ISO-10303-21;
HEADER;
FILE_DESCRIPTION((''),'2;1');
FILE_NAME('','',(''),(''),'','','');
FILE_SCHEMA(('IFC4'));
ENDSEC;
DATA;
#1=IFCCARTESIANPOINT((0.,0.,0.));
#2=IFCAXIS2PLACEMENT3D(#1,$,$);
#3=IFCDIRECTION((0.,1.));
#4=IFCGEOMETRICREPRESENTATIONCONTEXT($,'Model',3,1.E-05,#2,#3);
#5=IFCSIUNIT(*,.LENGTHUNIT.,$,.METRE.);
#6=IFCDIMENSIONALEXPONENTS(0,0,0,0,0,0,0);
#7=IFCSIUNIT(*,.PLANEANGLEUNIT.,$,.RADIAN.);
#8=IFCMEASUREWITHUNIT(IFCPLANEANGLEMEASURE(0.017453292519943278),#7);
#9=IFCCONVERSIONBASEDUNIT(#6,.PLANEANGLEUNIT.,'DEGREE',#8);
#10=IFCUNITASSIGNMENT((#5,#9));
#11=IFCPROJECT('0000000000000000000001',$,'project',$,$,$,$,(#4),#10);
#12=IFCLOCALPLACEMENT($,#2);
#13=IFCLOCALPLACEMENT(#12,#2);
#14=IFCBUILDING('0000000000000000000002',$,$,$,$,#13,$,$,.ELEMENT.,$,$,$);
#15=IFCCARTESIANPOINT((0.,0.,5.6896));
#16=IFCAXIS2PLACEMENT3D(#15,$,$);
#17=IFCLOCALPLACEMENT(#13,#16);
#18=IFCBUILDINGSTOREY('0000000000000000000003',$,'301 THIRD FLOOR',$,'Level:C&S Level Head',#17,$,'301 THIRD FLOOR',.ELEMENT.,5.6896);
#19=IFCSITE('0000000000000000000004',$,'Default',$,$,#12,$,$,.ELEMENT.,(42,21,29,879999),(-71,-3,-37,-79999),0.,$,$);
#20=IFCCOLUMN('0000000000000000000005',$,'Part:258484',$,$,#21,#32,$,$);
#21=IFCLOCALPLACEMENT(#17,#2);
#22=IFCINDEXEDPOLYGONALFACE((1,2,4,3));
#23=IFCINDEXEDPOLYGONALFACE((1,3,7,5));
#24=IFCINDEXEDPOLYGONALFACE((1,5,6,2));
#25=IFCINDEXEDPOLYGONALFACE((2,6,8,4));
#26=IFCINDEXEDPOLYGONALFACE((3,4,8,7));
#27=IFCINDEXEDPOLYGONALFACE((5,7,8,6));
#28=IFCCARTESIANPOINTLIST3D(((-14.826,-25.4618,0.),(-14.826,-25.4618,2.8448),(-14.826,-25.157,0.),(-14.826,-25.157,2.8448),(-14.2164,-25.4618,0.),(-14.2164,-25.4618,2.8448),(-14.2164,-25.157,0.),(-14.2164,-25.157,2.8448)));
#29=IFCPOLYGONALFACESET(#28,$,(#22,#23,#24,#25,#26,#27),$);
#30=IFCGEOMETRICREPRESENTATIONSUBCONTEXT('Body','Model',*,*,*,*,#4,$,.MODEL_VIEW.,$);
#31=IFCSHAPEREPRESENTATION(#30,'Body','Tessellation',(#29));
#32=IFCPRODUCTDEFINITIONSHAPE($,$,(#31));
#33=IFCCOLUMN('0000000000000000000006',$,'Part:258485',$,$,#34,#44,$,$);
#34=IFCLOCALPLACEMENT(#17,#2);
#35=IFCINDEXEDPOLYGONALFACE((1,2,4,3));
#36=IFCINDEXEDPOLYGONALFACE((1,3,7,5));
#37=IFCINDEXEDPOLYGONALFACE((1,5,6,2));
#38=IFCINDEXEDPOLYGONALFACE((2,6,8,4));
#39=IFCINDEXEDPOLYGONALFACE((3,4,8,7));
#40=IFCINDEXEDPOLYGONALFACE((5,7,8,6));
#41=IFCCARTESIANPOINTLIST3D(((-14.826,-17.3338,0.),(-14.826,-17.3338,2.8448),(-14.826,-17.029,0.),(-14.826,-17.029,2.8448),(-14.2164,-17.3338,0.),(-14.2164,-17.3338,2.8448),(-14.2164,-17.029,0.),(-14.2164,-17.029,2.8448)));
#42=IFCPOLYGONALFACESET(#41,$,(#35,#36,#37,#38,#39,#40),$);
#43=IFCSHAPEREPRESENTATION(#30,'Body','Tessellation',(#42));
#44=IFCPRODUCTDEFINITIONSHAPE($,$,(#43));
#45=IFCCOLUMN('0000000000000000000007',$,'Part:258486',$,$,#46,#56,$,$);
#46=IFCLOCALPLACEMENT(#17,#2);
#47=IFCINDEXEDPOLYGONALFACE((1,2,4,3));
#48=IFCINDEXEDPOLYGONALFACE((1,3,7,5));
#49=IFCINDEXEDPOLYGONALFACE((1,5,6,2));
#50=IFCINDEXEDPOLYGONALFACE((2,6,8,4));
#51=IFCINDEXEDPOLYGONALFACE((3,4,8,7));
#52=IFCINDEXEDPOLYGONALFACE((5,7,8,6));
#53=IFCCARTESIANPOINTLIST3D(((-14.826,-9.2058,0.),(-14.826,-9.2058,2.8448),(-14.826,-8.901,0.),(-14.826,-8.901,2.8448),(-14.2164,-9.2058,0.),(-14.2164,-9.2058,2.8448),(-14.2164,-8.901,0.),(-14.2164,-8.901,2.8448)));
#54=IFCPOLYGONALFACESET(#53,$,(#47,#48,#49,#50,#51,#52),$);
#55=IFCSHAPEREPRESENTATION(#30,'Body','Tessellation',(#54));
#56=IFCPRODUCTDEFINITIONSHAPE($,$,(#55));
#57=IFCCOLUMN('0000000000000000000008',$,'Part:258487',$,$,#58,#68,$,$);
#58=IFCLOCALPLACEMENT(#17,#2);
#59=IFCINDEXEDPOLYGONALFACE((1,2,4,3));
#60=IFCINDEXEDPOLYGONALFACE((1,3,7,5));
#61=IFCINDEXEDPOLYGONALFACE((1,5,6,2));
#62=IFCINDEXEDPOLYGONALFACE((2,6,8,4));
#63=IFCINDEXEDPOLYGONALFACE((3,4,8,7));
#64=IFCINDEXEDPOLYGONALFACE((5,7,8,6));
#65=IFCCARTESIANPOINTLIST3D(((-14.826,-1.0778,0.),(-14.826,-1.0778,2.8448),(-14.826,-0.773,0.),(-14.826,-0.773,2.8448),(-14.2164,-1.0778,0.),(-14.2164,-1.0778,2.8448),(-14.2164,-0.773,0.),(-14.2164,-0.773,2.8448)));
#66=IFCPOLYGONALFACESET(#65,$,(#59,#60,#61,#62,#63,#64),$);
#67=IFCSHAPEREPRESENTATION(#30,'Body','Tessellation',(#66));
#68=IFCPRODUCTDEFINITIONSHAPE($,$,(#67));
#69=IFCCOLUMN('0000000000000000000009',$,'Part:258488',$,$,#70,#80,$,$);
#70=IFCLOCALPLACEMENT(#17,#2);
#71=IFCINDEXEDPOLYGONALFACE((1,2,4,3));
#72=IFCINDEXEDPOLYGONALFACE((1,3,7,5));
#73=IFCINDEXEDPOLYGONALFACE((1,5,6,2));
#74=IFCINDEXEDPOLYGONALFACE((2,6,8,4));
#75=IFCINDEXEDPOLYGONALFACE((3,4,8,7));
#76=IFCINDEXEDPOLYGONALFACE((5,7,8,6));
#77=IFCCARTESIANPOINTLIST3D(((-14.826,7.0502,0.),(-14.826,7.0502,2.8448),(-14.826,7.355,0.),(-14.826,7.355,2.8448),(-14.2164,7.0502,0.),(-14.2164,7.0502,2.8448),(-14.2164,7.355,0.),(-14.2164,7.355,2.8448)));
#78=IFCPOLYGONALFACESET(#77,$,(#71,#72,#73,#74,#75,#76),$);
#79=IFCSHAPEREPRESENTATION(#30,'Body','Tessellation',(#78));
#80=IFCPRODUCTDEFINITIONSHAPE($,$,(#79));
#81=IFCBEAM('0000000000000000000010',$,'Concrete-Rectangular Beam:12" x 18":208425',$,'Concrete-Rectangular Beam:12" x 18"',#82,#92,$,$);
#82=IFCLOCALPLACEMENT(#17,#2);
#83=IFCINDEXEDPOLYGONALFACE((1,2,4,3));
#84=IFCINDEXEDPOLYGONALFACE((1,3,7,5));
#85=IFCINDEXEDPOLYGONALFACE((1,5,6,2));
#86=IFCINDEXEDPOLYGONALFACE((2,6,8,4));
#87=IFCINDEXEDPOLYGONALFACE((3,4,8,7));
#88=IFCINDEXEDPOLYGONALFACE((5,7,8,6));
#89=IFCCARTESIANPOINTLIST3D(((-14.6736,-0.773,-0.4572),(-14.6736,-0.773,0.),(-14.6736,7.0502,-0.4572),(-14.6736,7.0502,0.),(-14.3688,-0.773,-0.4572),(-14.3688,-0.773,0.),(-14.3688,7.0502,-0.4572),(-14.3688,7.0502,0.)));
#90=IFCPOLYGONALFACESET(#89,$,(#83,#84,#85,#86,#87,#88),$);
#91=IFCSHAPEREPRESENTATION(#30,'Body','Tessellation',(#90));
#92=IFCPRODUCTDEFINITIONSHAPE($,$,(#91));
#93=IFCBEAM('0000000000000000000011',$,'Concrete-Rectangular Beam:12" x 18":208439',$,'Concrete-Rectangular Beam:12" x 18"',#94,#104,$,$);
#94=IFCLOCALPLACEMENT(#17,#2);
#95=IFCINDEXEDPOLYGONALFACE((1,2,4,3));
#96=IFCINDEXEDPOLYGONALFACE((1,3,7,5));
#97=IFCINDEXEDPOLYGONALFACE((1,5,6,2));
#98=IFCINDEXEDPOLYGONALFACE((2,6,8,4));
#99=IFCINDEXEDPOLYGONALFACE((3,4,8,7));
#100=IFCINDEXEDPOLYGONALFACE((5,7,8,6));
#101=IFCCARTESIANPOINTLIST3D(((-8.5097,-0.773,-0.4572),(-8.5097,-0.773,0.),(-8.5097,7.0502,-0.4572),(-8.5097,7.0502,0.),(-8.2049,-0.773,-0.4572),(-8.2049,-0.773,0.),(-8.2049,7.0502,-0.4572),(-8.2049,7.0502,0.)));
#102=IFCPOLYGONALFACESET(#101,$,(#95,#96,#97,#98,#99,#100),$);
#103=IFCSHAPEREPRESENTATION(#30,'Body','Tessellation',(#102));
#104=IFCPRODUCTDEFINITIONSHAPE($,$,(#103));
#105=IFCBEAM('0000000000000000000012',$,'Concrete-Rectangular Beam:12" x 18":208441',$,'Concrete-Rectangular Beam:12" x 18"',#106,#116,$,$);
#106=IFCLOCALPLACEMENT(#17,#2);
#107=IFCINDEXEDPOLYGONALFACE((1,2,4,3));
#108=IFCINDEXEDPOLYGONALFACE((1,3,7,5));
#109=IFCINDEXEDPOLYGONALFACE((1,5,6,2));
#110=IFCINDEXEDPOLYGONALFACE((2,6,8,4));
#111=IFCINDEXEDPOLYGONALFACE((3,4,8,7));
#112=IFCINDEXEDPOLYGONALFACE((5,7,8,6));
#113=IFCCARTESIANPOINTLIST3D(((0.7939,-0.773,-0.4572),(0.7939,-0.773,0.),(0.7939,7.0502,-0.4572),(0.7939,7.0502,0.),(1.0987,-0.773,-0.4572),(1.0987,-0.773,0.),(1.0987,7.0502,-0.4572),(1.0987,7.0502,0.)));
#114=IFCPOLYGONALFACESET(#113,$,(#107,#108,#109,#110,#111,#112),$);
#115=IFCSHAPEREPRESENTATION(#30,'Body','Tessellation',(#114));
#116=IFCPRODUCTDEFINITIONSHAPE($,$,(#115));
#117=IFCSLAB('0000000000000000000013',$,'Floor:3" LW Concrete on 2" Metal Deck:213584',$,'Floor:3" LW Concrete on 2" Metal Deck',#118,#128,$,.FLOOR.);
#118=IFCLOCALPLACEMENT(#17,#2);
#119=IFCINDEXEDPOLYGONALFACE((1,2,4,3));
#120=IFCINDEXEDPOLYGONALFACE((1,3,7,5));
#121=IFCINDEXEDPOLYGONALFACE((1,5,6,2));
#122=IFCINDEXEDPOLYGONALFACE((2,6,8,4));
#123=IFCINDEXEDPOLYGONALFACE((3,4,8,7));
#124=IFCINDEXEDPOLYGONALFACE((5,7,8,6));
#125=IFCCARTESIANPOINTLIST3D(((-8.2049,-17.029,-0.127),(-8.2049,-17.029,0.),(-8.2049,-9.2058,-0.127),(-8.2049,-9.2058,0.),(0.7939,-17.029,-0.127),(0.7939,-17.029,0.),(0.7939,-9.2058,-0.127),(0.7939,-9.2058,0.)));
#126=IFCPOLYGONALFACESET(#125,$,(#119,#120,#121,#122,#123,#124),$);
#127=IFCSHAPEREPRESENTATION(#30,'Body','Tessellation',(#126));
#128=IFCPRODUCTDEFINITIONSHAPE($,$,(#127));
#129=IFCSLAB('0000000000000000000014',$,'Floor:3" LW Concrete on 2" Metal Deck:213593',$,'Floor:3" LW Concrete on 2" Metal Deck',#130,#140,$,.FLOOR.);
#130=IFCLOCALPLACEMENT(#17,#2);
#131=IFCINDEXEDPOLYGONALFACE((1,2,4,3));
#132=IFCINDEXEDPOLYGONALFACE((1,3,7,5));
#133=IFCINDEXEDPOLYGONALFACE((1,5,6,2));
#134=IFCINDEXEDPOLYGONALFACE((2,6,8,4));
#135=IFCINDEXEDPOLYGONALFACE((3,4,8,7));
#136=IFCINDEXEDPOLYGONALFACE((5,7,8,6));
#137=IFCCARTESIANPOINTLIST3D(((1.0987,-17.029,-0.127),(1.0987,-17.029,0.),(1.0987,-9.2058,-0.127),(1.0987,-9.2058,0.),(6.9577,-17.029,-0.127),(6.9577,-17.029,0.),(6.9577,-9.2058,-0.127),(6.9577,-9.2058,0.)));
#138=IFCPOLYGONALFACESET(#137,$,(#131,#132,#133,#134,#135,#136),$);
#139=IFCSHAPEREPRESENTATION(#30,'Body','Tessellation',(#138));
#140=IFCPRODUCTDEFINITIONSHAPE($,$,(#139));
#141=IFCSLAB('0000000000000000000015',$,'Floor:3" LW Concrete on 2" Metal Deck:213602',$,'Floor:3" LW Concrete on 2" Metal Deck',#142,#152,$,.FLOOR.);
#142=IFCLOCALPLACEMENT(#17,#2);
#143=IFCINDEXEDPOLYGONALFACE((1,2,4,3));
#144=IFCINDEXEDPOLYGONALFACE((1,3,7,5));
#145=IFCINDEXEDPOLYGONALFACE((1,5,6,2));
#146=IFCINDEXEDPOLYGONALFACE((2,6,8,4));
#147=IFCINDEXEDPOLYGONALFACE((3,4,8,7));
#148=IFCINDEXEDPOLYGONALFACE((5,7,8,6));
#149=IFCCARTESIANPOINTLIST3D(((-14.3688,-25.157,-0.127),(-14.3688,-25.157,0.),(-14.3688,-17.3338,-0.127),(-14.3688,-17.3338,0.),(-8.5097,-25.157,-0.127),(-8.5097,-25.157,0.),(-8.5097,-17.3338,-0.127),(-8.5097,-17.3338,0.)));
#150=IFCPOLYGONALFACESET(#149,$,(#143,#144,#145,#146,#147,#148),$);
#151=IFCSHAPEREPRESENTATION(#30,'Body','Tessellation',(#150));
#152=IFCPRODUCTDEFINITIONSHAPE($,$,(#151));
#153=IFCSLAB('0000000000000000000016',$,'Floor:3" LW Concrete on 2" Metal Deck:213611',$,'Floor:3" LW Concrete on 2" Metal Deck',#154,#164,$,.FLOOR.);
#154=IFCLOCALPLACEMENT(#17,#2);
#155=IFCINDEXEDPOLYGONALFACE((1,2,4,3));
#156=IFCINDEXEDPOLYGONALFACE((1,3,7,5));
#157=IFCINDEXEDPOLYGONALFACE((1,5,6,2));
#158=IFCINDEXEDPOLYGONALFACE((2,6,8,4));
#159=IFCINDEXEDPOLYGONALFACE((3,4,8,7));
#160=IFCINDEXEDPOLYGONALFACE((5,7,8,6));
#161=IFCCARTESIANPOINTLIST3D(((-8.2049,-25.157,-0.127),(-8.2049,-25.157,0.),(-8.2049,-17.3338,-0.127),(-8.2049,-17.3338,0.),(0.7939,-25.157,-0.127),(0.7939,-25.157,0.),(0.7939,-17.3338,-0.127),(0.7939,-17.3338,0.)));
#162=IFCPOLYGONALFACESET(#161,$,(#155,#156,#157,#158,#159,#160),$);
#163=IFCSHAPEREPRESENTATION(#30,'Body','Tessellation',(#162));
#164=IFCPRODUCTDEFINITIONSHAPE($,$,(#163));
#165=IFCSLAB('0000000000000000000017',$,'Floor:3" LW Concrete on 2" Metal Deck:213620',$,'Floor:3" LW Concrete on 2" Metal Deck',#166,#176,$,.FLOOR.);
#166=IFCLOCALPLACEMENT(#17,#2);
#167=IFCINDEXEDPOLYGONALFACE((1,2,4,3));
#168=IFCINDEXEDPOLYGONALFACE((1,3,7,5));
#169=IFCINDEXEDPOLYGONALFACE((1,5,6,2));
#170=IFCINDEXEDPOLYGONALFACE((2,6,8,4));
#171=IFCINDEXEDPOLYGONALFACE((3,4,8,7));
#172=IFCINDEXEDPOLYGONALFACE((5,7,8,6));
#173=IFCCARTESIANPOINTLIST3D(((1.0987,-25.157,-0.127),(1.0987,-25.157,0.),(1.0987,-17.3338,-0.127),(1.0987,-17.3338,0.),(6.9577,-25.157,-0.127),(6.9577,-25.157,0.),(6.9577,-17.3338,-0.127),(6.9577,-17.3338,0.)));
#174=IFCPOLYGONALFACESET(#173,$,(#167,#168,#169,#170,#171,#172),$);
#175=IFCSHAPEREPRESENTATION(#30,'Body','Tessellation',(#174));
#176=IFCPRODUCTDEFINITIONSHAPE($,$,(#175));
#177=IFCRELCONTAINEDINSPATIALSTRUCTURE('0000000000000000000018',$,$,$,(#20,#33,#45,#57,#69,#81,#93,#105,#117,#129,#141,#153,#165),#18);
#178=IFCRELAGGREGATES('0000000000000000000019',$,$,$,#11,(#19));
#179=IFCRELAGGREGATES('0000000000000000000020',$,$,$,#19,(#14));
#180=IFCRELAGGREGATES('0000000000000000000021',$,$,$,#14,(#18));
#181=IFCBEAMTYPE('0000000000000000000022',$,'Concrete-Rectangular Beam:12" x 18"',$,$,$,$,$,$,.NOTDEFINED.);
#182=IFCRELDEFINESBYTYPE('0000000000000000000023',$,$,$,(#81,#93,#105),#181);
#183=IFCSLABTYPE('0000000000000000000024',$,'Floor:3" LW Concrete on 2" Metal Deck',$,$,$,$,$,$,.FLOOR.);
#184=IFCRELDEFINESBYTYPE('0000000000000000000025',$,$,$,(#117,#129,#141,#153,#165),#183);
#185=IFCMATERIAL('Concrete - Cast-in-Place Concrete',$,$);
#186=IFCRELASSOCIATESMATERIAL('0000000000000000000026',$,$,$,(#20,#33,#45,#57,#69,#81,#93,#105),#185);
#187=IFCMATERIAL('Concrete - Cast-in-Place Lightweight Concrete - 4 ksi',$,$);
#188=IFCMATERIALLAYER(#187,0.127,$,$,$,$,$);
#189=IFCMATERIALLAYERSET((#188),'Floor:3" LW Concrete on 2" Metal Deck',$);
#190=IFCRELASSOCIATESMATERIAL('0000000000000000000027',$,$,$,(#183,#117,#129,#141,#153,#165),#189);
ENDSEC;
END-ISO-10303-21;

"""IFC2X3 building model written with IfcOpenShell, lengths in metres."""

from ifc_helpers import new_model, entity, si_unit, converted_unit, direction, frame, frame_2d, origin, origin_2d_with_axis, place, context, subcontext, project, spatial, rectangle, extrude, material, layer, layer_set, layer_usage, type_object, element, save


model = new_model("IFC2X3")

# Units and contexts
model_context = context("Model", 3, precision=1e-05, world=origin(), true_north=direction((0.0, 1.0)))
body_context = subcontext(model_context, "Body", "Model", "MODEL_VIEW")
ifc_project = project(units=[si_unit("LENGTHUNIT", "METRE"), converted_unit("PLANEANGLEUNIT", "DEGREE", entity("IfcPlaneAngleMeasure", 0.017453292519943278), si_unit("PLANEANGLEUNIT", "RADIAN"), dimensions=[0, 0, 0, 0, 0, 0, 0])], contexts=[model_context])

# Site, building, storey
site_placement = place(None, origin())
site = spatial("IfcSite", under=ifc_project, at=site_placement, Name="Default", CompositionType="ELEMENT", RefLatitude=(42, 21, 29, 879999), RefLongitude=(-71, -3, -37, -79999), RefElevation=0.0)
building_placement = place(site_placement, origin())
building = spatial("IfcBuilding", under=site, at=building_placement, CompositionType="ELEMENT")
storey_placement = place(building_placement, frame((0.0, 0.0, 5.6896)))
storey = spatial("IfcBuildingStorey", under=building, at=storey_placement, Name="301 THIRD FLOOR", ObjectType="Level:C&S Level Head", LongName="301 THIRD FLOOR", CompositionType="ELEMENT", Elevation=5.6896)

# Columns
ifc_material_1 = material(Name="Concrete - Cast-in-Place Concrete")
column_1_placement = place(storey_placement, origin())
element("IfcColumn", 1, at=column_1_placement, inside=storey, material=ifc_material_1, Name="Part:258484", context=body_context, shape_type="SweptSolid", body=[
    extrude(rectangle(XDim=2.8448, YDim=0.3048, at=frame_2d((0.0, 0.0), x_axis=(1.0, 0.0))), frame((-14.826, -25.3094, 1.4224), z_axis=(1.0, 0.0, 0.0), x_axis=(0.0, 0.0, -1.0)), (0.0, 0.0, 1.0), 0.6096),
])
column_2_placement = place(storey_placement, origin())
element("IfcColumn", 2, at=column_2_placement, inside=storey, material=ifc_material_1, Name="Part:258485", context=body_context, shape_type="SweptSolid", body=[
    extrude(rectangle(XDim=2.8448, YDim=0.3048, at=frame_2d((0.0, 0.0), x_axis=(1.0, 0.0))), frame((-14.826, -17.1814, 1.4224), z_axis=(1.0, 0.0, 0.0), x_axis=(0.0, 0.0, -1.0)), (0.0, 0.0, 1.0), 0.6096),
])
column_3_placement = place(storey_placement, origin())
element("IfcColumn", 3, at=column_3_placement, inside=storey, material=ifc_material_1, Name="Part:258486", context=body_context, shape_type="SweptSolid", body=[
    extrude(rectangle(XDim=2.8448, YDim=0.3048, at=frame_2d((0.0, 0.0), x_axis=(1.0, 0.0))), frame((-14.826, -9.0534, 1.4224), z_axis=(1.0, 0.0, 0.0), x_axis=(0.0, 0.0, -1.0)), (0.0, 0.0, 1.0), 0.6096),
])
column_4_placement = place(storey_placement, origin())
element("IfcColumn", 4, at=column_4_placement, inside=storey, material=ifc_material_1, Name="Part:258487", context=body_context, shape_type="SweptSolid", body=[
    extrude(rectangle(XDim=2.8448, YDim=0.3048, at=frame_2d((0.0, 0.0), x_axis=(1.0, 0.0))), frame((-14.826, -0.9254, 1.4224), z_axis=(1.0, 0.0, 0.0), x_axis=(0.0, 0.0, -1.0)), (0.0, 0.0, 1.0), 0.6096),
])
column_5_placement = place(storey_placement, origin())
element("IfcColumn", 5, at=column_5_placement, inside=storey, material=ifc_material_1, Name="Part:258488", context=body_context, shape_type="SweptSolid", body=[
    extrude(rectangle(XDim=2.8448, YDim=0.3048, at=frame_2d((0.0, 0.0), x_axis=(1.0, 0.0))), frame((-14.826, 7.2026, 1.4224), z_axis=(1.0, 0.0, 0.0), x_axis=(0.0, 0.0, -1.0)), (0.0, 0.0, 1.0), 0.6096),
])

# Beams
beam_type = type_object("IfcBeamType", Name="Concrete-Rectangular Beam:12\" x 18\"", PredefinedType="NOTDEFINED")
beam_1_placement = place(storey_placement, frame((-14.5212, 7.0502, 0.0), z_axis=(0.0, 0.0, 1.0), x_axis=(0.0, -1.0, 0.0)))
element("IfcBeam", 6, at=beam_1_placement, inside=storey, type_object=beam_type, material=ifc_material_1, Name="Concrete-Rectangular Beam:12\" x 18\":208425", ObjectType="Concrete-Rectangular Beam:12\" x 18\"", context=body_context, shape_type="SweptSolid", body=[
    extrude(rectangle(XDim=0.4572, YDim=0.3048, at=origin_2d_with_axis()), frame((0.0, 0.0, -0.2286), z_axis=(1.0, 0.0, 0.0), x_axis=(0.0, 0.0, -1.0)), (0.0, 0.0, 1.0), 7.8232),
])
beam_2_placement = place(storey_placement, frame((-8.3573, 7.0502, 0.0), z_axis=(0.0, 0.0, 1.0), x_axis=(0.0, -1.0, 0.0)))
element("IfcBeam", 7, at=beam_2_placement, inside=storey, type_object=beam_type, material=ifc_material_1, Name="Concrete-Rectangular Beam:12\" x 18\":208439", ObjectType="Concrete-Rectangular Beam:12\" x 18\"", context=body_context, shape_type="SweptSolid", body=[
    extrude(rectangle(XDim=0.4572, YDim=0.3048, at=frame_2d((0.0, 0.0), x_axis=(1.0, 0.0))), frame((0.0, 0.0, -0.2286), z_axis=(1.0, 0.0, 0.0), x_axis=(0.0, 0.0, -1.0)), (0.0, 0.0, 1.0), 7.8232),
])
beam_3_placement = place(storey_placement, frame((0.9463, 7.0502, 0.0), z_axis=(0.0, 0.0, 1.0), x_axis=(0.0, -1.0, 0.0)))
element("IfcBeam", 8, at=beam_3_placement, inside=storey, type_object=beam_type, material=ifc_material_1, Name="Concrete-Rectangular Beam:12\" x 18\":208441", ObjectType="Concrete-Rectangular Beam:12\" x 18\"", context=body_context, shape_type="SweptSolid", body=[
    extrude(rectangle(XDim=0.4572, YDim=0.3048, at=origin_2d_with_axis()), frame((0.0, 0.0, -0.2286), z_axis=(1.0, 0.0, 0.0), x_axis=(0.0, 0.0, -1.0)), (0.0, 0.0, 1.0), 7.8232),
])

# Slabs
ifc_material_2 = material(Name="Concrete - Cast-in-Place Lightweight Concrete - 4 ksi")
ifc_layer = layer(ifc_material_2, 0.127)
ifc_layer_set = layer_set([ifc_layer], Name="Floor:3\" LW Concrete on 2\" Metal Deck")
ifc_layer_usage_1 = layer_usage(ifc_layer_set, "AXIS3", "POSITIVE", 0.0)
slab_type = type_object("IfcSlabType", Name="Floor:3\" LW Concrete on 2\" Metal Deck", PredefinedType="FLOOR", material=ifc_layer_set)
slab_1_placement = place(storey_placement, origin())
element("IfcSlab", 9, at=slab_1_placement, inside=storey, type_object=slab_type, material=ifc_layer_usage_1, Name="Floor:3\" LW Concrete on 2\" Metal Deck:213584", ObjectType="Floor:3\" LW Concrete on 2\" Metal Deck", PredefinedType="FLOOR", context=body_context, shape_type="SweptSolid", body=[
    extrude(rectangle(XDim=7.8232, YDim=8.9988, at=frame_2d((0.0, 0.0), x_axis=(1.0, 0.0))), frame((-3.7055, -13.1174, 0.0), z_axis=(0.0, 0.0, -1.0), x_axis=(0.0, 1.0, 0.0)), (0.0, 0.0, 1.0), 0.127),
])
ifc_layer_usage_2 = layer_usage(ifc_layer_set, "AXIS3", "POSITIVE", 0.0)
slab_2_placement = place(storey_placement, origin())
element("IfcSlab", 10, at=slab_2_placement, inside=storey, type_object=slab_type, material=ifc_layer_usage_2, Name="Floor:3\" LW Concrete on 2\" Metal Deck:213593", ObjectType="Floor:3\" LW Concrete on 2\" Metal Deck", PredefinedType="FLOOR", context=body_context, shape_type="SweptSolid", body=[
    extrude(rectangle(XDim=7.8232, YDim=5.859, at=frame_2d((0.0, 0.0), x_axis=(1.0, 0.0))), frame((4.0282, -13.1174, 0.0), z_axis=(0.0, 0.0, -1.0), x_axis=(0.0, 1.0, 0.0)), (0.0, 0.0, 1.0), 0.127),
])
ifc_layer_usage_3 = layer_usage(ifc_layer_set, "AXIS3", "POSITIVE", 0.0)
slab_3_placement = place(storey_placement, origin())
element("IfcSlab", 11, at=slab_3_placement, inside=storey, type_object=slab_type, material=ifc_layer_usage_3, Name="Floor:3\" LW Concrete on 2\" Metal Deck:213602", ObjectType="Floor:3\" LW Concrete on 2\" Metal Deck", PredefinedType="FLOOR", context=body_context, shape_type="SweptSolid", body=[
    extrude(rectangle(XDim=7.8232, YDim=5.859, at=frame_2d((0.0, 0.0), x_axis=(1.0, 0.0))), frame((-11.4393, -21.2454, 0.0), z_axis=(0.0, 0.0, -1.0), x_axis=(0.0, 1.0, 0.0)), (0.0, 0.0, 1.0), 0.127),
])
ifc_layer_usage_4 = layer_usage(ifc_layer_set, "AXIS3", "POSITIVE", 0.0)
slab_4_placement = place(storey_placement, origin())
element("IfcSlab", 12, at=slab_4_placement, inside=storey, type_object=slab_type, material=ifc_layer_usage_4, Name="Floor:3\" LW Concrete on 2\" Metal Deck:213611", ObjectType="Floor:3\" LW Concrete on 2\" Metal Deck", PredefinedType="FLOOR", context=body_context, shape_type="SweptSolid", body=[
    extrude(rectangle(XDim=7.8232, YDim=8.9988, at=frame_2d((0.0, 0.0), x_axis=(1.0, 0.0))), frame((-3.7055, -21.2454, 0.0), z_axis=(0.0, 0.0, -1.0), x_axis=(0.0, 1.0, 0.0)), (0.0, 0.0, 1.0), 0.127),
])
ifc_layer_usage_5 = layer_usage(ifc_layer_set, "AXIS3", "POSITIVE", 0.0)
slab_5_placement = place(storey_placement, origin())
element("IfcSlab", 13, at=slab_5_placement, inside=storey, type_object=slab_type, material=ifc_layer_usage_5, Name="Floor:3\" LW Concrete on 2\" Metal Deck:213620", ObjectType="Floor:3\" LW Concrete on 2\" Metal Deck", PredefinedType="FLOOR", context=body_context, shape_type="SweptSolid", body=[
    extrude(rectangle(XDim=7.8232, YDim=5.859, at=frame_2d((0.0, 0.0), x_axis=(1.0, 0.0))), frame((4.0282, -21.2454, 0.0), z_axis=(0.0, 0.0, -1.0), x_axis=(0.0, 1.0, 0.0)), (0.0, 0.0, 1.0), 0.127),
])

save(model, "model.ifc")
